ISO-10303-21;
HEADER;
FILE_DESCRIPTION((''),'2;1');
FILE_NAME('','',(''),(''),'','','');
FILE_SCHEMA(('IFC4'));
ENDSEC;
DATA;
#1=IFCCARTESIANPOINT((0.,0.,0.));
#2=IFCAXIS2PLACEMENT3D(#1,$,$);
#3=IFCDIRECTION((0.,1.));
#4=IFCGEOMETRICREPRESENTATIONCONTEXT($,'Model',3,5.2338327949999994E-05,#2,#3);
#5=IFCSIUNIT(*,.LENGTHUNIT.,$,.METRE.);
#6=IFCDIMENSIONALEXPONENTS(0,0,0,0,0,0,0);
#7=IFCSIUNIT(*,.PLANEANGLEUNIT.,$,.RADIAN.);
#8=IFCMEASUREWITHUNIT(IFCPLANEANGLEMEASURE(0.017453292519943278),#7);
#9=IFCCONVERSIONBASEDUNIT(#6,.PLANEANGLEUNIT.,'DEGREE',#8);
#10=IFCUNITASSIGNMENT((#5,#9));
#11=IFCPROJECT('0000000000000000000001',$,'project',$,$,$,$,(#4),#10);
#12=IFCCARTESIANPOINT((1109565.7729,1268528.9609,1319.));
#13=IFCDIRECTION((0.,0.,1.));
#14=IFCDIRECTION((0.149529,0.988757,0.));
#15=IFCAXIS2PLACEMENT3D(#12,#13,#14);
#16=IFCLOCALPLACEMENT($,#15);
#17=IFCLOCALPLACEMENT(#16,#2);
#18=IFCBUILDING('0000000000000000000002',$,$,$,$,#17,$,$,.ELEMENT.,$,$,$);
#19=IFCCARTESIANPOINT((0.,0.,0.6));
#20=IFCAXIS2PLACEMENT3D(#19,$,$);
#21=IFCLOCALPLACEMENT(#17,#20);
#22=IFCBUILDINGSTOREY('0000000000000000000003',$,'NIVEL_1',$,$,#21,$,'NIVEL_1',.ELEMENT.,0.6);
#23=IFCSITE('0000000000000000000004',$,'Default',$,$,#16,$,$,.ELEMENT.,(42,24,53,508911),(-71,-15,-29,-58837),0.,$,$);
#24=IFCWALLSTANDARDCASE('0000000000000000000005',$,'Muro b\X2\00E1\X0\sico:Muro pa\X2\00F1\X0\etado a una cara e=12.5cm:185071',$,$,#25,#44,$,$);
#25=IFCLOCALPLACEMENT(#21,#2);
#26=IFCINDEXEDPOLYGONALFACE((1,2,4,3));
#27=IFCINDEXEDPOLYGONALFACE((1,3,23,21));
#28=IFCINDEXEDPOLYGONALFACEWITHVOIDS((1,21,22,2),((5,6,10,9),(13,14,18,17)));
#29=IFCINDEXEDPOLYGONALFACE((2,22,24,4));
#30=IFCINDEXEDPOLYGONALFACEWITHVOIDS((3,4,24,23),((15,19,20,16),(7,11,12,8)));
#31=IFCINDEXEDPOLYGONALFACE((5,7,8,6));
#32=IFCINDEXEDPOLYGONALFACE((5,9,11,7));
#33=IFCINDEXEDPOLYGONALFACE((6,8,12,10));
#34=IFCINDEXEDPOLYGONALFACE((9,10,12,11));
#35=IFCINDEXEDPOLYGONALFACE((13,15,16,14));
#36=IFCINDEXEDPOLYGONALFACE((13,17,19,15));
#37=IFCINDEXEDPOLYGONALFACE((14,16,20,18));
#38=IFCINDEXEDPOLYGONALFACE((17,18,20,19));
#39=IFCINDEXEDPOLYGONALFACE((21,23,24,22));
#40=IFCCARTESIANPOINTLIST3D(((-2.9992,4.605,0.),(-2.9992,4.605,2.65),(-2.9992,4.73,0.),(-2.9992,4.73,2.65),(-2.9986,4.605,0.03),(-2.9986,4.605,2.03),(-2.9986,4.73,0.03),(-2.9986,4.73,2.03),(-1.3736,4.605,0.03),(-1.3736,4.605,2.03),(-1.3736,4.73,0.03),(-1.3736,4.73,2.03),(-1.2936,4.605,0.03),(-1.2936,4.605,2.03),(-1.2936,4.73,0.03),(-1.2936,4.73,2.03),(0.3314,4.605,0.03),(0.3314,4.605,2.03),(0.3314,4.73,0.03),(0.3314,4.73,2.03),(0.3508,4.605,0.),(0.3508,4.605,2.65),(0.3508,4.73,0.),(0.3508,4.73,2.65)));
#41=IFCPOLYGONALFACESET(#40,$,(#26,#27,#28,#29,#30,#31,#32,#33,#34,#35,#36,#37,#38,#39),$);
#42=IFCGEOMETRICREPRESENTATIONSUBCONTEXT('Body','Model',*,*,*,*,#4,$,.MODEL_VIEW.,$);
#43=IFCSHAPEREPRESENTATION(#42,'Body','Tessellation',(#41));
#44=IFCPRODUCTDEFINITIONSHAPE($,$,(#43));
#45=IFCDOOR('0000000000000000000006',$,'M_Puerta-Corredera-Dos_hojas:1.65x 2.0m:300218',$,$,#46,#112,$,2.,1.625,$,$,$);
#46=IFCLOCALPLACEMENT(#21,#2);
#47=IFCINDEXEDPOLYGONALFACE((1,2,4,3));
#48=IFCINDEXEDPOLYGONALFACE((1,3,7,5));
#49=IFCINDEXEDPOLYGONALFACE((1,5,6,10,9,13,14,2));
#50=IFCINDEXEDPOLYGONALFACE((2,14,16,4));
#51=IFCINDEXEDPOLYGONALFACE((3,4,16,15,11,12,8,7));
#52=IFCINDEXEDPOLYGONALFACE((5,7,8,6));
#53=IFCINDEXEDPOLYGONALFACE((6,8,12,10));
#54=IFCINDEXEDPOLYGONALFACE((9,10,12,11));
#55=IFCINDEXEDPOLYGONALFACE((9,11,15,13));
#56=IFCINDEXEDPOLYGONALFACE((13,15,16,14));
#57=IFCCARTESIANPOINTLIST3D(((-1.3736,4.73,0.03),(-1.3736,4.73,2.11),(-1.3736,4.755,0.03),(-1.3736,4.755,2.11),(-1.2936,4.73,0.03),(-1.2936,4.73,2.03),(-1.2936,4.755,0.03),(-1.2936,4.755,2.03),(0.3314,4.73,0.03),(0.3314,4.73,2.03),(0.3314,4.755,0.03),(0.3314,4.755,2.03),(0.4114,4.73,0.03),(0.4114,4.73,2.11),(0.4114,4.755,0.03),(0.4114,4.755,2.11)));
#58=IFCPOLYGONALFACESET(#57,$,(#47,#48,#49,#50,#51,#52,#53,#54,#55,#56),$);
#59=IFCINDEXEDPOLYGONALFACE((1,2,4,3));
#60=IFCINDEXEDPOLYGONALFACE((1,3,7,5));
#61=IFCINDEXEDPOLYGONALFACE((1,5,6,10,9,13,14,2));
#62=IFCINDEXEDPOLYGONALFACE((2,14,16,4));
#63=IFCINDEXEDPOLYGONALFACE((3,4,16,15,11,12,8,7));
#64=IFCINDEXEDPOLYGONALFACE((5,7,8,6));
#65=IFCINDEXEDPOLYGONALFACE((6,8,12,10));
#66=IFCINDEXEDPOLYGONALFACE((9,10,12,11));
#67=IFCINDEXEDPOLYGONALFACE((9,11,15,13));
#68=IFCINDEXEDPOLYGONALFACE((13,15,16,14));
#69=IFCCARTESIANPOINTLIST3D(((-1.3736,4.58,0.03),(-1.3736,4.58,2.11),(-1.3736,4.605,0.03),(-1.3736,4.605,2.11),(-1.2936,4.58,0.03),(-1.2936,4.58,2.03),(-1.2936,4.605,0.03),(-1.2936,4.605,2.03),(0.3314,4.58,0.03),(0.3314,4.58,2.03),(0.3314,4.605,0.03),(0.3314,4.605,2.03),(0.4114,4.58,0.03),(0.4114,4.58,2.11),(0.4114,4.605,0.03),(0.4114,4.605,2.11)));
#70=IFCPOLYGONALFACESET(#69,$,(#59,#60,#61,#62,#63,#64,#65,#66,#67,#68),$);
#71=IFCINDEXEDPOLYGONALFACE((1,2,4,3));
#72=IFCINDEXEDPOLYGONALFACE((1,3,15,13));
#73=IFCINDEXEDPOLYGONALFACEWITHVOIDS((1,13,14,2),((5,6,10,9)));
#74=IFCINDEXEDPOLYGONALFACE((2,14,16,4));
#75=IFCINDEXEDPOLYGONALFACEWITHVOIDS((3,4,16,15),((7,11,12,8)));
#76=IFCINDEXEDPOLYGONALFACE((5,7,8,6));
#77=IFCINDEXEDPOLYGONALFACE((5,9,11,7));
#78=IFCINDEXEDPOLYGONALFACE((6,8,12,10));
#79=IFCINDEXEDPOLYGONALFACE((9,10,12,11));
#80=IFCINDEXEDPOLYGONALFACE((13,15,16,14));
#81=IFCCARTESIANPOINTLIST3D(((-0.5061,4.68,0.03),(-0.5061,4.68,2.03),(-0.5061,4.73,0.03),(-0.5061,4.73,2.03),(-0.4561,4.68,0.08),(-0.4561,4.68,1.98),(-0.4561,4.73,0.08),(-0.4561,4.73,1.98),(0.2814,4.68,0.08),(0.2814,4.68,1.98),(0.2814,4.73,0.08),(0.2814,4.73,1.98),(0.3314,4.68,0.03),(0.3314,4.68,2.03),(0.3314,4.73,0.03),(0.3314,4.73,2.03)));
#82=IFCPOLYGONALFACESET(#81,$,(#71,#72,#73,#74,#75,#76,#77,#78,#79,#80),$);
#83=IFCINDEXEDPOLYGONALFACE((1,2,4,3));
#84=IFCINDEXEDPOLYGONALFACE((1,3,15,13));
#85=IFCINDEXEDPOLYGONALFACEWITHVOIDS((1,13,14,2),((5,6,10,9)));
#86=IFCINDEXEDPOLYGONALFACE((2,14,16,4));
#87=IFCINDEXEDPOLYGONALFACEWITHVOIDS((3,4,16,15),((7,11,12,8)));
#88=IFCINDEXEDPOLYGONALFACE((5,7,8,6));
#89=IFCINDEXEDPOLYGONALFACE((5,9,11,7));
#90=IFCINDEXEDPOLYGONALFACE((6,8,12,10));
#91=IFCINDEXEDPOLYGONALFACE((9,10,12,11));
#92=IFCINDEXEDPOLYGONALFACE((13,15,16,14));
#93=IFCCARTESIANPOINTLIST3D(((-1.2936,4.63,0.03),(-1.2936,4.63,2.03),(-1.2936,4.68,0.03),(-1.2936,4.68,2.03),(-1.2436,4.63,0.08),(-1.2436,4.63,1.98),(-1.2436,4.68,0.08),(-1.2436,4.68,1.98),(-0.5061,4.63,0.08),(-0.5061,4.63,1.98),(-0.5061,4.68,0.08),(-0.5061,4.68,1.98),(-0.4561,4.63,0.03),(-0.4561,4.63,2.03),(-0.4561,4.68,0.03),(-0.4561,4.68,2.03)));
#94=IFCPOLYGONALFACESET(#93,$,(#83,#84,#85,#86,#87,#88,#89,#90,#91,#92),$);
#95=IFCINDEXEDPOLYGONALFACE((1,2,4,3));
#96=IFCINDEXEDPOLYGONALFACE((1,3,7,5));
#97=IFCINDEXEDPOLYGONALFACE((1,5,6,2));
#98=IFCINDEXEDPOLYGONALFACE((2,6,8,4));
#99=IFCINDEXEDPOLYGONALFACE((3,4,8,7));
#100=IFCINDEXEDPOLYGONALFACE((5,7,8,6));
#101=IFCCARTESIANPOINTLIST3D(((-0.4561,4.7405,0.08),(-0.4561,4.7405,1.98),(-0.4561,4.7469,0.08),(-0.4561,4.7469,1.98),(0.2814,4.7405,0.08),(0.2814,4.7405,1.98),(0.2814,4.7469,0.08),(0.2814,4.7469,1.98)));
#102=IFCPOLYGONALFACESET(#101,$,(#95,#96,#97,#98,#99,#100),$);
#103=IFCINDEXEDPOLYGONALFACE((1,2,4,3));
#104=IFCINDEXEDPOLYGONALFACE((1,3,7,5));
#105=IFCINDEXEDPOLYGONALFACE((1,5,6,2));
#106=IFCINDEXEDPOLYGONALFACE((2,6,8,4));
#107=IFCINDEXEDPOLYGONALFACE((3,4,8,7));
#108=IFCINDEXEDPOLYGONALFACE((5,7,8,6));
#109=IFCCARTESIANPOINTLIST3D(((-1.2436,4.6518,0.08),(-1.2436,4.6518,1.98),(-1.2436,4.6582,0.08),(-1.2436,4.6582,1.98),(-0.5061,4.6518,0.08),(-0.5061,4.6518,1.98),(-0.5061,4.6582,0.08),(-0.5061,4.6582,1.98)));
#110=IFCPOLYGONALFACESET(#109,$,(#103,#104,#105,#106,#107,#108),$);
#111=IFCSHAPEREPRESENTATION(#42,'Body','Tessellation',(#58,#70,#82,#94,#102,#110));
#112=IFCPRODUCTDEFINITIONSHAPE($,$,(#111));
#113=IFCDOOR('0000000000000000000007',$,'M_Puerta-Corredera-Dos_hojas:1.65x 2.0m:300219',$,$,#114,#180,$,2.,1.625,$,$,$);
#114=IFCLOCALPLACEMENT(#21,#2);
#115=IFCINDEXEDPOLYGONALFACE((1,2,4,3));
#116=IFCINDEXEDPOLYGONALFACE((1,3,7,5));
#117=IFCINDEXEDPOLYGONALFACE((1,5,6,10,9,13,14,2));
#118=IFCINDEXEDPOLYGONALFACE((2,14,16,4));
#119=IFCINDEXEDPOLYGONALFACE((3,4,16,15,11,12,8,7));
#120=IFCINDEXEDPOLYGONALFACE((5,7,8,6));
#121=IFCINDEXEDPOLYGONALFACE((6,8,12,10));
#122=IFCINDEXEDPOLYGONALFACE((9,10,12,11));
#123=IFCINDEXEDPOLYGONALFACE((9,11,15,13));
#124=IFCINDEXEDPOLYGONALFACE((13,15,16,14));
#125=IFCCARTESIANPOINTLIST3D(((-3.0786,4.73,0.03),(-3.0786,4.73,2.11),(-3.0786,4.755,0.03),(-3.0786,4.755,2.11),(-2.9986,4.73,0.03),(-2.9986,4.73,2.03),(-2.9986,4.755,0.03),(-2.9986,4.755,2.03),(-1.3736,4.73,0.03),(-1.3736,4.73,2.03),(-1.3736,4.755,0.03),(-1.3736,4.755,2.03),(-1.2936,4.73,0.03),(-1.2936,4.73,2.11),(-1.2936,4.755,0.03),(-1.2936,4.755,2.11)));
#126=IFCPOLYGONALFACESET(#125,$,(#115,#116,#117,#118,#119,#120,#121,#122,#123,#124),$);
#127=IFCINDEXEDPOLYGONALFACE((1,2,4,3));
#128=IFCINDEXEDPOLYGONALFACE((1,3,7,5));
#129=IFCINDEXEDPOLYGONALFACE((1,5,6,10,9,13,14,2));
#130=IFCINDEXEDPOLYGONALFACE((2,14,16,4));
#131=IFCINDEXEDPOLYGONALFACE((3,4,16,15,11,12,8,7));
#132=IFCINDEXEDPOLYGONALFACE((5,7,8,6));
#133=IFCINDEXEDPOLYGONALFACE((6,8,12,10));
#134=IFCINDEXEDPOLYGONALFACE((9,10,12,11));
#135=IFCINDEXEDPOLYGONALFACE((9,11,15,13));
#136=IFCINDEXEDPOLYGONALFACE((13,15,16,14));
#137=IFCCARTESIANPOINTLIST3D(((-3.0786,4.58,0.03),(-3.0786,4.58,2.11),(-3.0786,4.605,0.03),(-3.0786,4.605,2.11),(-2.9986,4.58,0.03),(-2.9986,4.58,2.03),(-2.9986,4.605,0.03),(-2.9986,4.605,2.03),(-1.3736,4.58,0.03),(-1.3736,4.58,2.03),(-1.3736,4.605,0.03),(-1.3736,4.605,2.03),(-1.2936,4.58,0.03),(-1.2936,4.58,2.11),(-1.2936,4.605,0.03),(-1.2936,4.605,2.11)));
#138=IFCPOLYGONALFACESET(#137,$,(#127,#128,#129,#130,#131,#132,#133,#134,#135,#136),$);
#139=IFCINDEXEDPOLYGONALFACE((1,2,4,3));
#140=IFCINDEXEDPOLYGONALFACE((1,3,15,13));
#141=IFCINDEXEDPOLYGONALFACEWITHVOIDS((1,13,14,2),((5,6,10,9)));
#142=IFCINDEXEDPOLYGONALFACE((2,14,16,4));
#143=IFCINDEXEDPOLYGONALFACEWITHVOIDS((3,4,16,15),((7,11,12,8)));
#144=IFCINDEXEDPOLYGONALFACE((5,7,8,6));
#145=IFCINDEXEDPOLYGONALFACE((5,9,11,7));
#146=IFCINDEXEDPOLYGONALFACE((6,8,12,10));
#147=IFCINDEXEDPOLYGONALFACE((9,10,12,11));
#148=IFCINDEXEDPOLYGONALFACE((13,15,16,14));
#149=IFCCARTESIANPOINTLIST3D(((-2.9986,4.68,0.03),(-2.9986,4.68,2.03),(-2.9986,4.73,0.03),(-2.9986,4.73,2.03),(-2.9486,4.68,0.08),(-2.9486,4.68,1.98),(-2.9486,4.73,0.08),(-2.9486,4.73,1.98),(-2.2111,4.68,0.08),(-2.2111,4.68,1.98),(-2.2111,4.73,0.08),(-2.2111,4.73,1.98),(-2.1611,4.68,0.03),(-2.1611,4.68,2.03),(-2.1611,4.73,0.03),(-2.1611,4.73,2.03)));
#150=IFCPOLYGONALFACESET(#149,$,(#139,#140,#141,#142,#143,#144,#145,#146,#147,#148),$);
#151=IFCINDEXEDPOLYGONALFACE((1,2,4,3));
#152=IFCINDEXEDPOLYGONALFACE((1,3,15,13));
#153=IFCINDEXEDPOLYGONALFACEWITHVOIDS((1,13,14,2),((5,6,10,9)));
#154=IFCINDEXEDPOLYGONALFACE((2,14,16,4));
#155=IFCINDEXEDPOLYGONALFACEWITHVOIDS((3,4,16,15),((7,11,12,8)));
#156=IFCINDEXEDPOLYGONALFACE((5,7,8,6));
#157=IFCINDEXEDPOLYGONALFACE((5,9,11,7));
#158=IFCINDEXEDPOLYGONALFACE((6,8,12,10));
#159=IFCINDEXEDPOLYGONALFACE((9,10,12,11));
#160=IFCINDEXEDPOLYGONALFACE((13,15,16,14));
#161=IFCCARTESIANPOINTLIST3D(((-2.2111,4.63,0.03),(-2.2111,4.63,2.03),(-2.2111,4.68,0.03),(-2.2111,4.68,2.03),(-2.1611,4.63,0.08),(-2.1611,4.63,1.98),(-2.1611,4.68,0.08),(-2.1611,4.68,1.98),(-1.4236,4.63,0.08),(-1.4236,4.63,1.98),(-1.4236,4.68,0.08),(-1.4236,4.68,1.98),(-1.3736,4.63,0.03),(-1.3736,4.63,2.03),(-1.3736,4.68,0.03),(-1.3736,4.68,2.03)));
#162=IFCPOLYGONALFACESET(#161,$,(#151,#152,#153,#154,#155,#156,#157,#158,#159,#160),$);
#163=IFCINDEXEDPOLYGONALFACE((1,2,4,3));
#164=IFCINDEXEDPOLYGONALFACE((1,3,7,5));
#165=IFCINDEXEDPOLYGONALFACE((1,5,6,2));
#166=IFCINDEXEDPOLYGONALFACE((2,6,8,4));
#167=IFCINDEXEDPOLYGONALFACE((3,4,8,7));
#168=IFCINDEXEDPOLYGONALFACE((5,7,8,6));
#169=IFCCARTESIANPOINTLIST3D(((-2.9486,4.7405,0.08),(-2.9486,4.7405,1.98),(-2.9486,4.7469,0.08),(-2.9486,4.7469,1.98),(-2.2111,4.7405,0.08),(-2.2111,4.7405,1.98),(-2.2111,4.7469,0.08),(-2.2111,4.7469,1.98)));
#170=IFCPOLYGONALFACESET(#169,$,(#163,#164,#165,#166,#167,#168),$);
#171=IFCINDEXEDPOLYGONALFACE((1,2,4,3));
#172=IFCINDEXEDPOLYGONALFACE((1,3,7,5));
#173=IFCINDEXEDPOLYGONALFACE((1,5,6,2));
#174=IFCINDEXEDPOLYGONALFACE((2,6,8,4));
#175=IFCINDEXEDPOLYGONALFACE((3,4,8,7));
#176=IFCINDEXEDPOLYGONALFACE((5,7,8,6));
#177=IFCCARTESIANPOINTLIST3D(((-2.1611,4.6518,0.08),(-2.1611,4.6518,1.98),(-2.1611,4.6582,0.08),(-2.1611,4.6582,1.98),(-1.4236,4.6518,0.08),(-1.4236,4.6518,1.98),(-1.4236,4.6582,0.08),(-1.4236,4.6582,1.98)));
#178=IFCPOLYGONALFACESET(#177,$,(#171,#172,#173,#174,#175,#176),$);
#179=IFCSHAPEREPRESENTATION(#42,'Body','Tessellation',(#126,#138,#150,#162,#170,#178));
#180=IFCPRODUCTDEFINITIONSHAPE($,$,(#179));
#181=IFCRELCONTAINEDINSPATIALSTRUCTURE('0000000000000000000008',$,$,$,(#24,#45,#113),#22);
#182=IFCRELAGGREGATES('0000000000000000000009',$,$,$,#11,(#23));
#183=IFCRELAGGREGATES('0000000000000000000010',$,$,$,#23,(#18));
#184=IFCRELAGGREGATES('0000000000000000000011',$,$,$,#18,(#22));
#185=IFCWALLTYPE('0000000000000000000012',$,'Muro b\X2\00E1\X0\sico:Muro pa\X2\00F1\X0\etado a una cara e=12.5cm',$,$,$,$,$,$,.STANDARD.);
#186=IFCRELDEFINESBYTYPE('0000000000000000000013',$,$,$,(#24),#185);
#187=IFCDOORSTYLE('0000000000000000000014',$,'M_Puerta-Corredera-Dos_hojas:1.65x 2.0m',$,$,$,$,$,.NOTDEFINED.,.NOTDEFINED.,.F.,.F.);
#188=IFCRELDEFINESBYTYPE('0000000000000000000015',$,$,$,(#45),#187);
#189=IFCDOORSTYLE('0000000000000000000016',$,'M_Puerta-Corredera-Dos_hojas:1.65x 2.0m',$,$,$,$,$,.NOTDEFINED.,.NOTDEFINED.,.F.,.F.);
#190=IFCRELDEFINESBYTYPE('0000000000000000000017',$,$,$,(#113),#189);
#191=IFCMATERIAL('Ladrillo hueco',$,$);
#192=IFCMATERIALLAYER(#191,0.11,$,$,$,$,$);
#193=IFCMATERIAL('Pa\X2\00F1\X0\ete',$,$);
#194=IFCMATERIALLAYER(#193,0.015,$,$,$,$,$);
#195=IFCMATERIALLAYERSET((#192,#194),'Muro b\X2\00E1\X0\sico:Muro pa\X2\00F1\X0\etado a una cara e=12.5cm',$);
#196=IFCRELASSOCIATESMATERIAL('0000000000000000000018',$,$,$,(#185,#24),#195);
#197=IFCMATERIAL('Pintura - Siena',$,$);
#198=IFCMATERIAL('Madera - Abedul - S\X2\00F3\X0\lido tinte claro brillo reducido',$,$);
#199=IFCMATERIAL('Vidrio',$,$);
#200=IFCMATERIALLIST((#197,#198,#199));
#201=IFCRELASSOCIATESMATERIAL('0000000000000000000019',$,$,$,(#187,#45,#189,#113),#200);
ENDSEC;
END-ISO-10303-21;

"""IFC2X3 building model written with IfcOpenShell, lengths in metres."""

from ifc_helpers import new_model, entity, si_unit, converted_unit, direction, frame, frame_2d, origin, origin_2d_with_axis, place, context, subcontext, project, spatial, polyline, rectangle, outline, extrude, source, transform, mapped, material, material_list, layer, layer_set, layer_usage, type_object, type_shapes, element, fill, save


model = new_model("IFC2X3")

# Units and contexts
model_context = context("Model", 3, precision=5.2338327949999994e-05, world=origin(), true_north=direction((0.0, 1.0)))
body_context = subcontext(model_context, "Body", "Model", "MODEL_VIEW")
ifc_project = project(units=[si_unit("LENGTHUNIT", "METRE"), converted_unit("PLANEANGLEUNIT", "DEGREE", entity("IfcPlaneAngleMeasure", 0.017453292519943278), si_unit("PLANEANGLEUNIT", "RADIAN"), dimensions=[0, 0, 0, 0, 0, 0, 0])], contexts=[model_context])

# Site, building, storey
site_placement = place(None, frame((1109565.7729, 1268528.9609, 1319.0), z_axis=(0.0, 0.0, 1.0), x_axis=(0.149529, 0.988757, 0.0)))
site = spatial("IfcSite", under=ifc_project, at=site_placement, Name="Default", CompositionType="ELEMENT", RefLatitude=(42, 24, 53, 508911), RefLongitude=(-71, -15, -29, -58837), RefElevation=0.0)
building_placement = place(site_placement, origin())
building = spatial("IfcBuilding", under=site, at=building_placement, CompositionType="ELEMENT")
storey_placement = place(building_placement, frame((0.0, 0.0, 0.6)))
storey = spatial("IfcBuildingStorey", under=building, at=storey_placement, Name="NIVEL_1", LongName="NIVEL_1", CompositionType="ELEMENT", Elevation=0.6)

# Shared definitions
ifc_material_1 = material(Name="Pañete")
ifc_material_2 = material(Name="Ladrillo hueco")

# Wall, openings, doors
ifc_layer_1 = layer(ifc_material_2, 0.11)
ifc_layer_2 = layer(ifc_material_1, 0.015)
ifc_layer_set_1 = layer_set([ifc_layer_1, ifc_layer_2], Name="Muro básico:Muro pañetado a una cara e=12.5cm")
ifc_layer_usage_1 = layer_usage(ifc_layer_set_1, "AXIS2", "NEGATIVE", 0.0625)
wall_type_1 = type_object("IfcWallType", Name="Muro básico:Muro pañetado a una cara e=12.5cm", PredefinedType="STANDARD", material=ifc_layer_set_1)
wall_1_placement = place(storey_placement, frame((-2.9992, 4.6675, 0.0)))
wall_1 = element("IfcWallStandardCase", 1, at=wall_1_placement, inside=storey, type_object=wall_type_1, material=ifc_layer_usage_1, Name="Muro básico:Muro pañetado a una cara e=12.5cm:185071", context=body_context, shape_type="SweptSolid", body=[
    extrude(rectangle(XDim=3.35, YDim=0.125, at=frame_2d((1.675, 0.0), x_axis=(-1.0, 0.0))), origin(), (0.0, 0.0, 1.0), 2.65),
])
opening_1_placement = place(wall_1_placement, frame((0.0006, -0.0625, 0.03)))
opening_1 = element("IfcOpeningElement", 2, at=opening_1_placement, cuts=wall_1, ObjectType="Opening", context=body_context, shape_type="SweptSolid", body=[
    extrude(rectangle(XDim=2.0, YDim=1.625, at=frame_2d((1.0, 0.8125), x_axis=(-1.0, 0.0))), frame((0.0, 0.0, 0.0), z_axis=(0.0, 1.0, 0.0), x_axis=(0.0, 0.0, 1.0)), (0.0, 0.0, 1.0), 0.125),
])
opening_2_placement = place(wall_1_placement, frame((1.7056, -0.0625, 0.03)))
opening_2 = element("IfcOpeningElement", 3, at=opening_2_placement, cuts=wall_1, ObjectType="Opening", context=body_context, shape_type="SweptSolid", body=[
    extrude(rectangle(XDim=2.0, YDim=1.625, at=frame_2d((1.0, 0.8125), x_axis=(-1.0, 0.0))), frame((0.0, 0.0, 0.0), z_axis=(0.0, 1.0, 0.0), x_axis=(0.0, 0.0, 1.0)), (0.0, 0.0, 1.0), 0.125),
])
ifc_material_3 = material(Name="Pintura - Siena")
ifc_material_4 = material(Name="Madera - Abedul - Sólido tinte claro brillo reducido")
ifc_material_5 = material(Name="Vidrio")
ifc_material_list = material_list([ifc_material_3, ifc_material_4, ifc_material_5])
door_style_1 = type_object("IfcDoorStyle", Name="M_Puerta-Corredera-Dos_hojas:1.65x 2.0m", ConstructionType="NOTDEFINED", OperationType="NOTDEFINED", ParameterTakesPrecedence=False, Sizeable=False, material=ifc_material_list)
shared_shape_1 = source(origin(), body_context, "Body", "SweptSolid", [
    extrude(outline(polyline([(-0.8925, -1.02), (-0.8125, -1.02), (-0.8125, 0.98), (0.8125, 0.98), (0.8125, -1.02), (0.8925, -1.02), (0.8925, 1.06), (-0.8925, 1.06), (-0.8925, -1.02)])), frame((0.8125, 0.404, 1.02), z_axis=(0.0, -1.0, 0.0), x_axis=(1.0, 0.0, 0.0)), (0.0, 0.0, 1.0), 0.025),
    extrude(outline(polyline([(-1.02, -0.8925), (1.06, -0.8925), (1.06, 0.8925), (-1.02, 0.8925), (-1.02, 0.8125), (0.98, 0.8125), (0.98, -0.8125), (-1.02, -0.8125), (-1.02, -0.8925)])), frame((0.8125, 0.254, 1.02), z_axis=(0.0, -1.0, 0.0), x_axis=(0.0, 0.0, 1.0)), (0.0, 0.0, 1.0), 0.025),
    extrude(outline(polyline([(-1.0, -0.4187), (1.0, -0.4187), (1.0, 0.4187), (-1.0, 0.4187), (-1.0, -0.4187)]), holes=[polyline([(-0.95, -0.3688), (-0.95, 0.3687), (0.95, 0.3687), (0.95, -0.3688), (-0.95, -0.3688)])]), frame((1.2063, 0.379, 1.0), z_axis=(0.0, -1.0, 0.0), x_axis=(0.0, 0.0, -1.0)), (0.0, 0.0, 1.0), 0.05),
    extrude(outline(polyline([(-0.4187, -1.0), (0.4187, -1.0), (0.4187, 1.0), (-0.4187, 1.0), (-0.4187, -1.0)]), holes=[polyline([(-0.3688, -0.95), (-0.3688, 0.95), (0.3688, 0.95), (0.3688, -0.95), (-0.3688, -0.95)])]), frame((0.4187, 0.329, 1.0), z_axis=(0.0, -1.0, 0.0), x_axis=(-1.0, 0.0, 0.0)), (0.0, 0.0, 1.0), 0.05),
    extrude(rectangle(XDim=0.7375, YDim=0.0064, at=origin_2d_with_axis()), frame((1.2062, 0.3927, 0.05)), (0.0, 0.0, 1.0), 1.9),
    extrude(rectangle(XDim=0.7375, YDim=0.0063, at=frame_2d((0.0, 0.0), x_axis=(1.0, 0.0))), frame((0.4187, 0.304, 0.05), z_axis=(0.0, 0.0, 1.0), x_axis=(-1.0, 0.0, 0.0)), (0.0, 0.0, 1.0), 1.9),
])
type_shapes(door_style_1, [shared_shape_1])
door_1_placement = place(opening_2_placement, frame((0.0, -0.254, 0.0)))
door_1 = element("IfcDoor", 4, at=door_1_placement, inside=storey, type_object=door_style_1, material=ifc_material_list, Name="M_Puerta-Corredera-Dos_hojas:1.65x 2.0m:300218", OverallHeight=2.0, OverallWidth=1.625, context=body_context, shape_type="MappedRepresentation", body=[
    mapped(shared_shape_1, transform((0.0, 0.0, 0.0), scale=1.0)),
])
fill(opening_2, door_1)
door_style_2 = type_object("IfcDoorStyle", Name="M_Puerta-Corredera-Dos_hojas:1.65x 2.0m", ConstructionType="NOTDEFINED", OperationType="NOTDEFINED", ParameterTakesPrecedence=False, Sizeable=False, material=ifc_material_list)
shared_shape_2 = source(origin(), body_context, "Body", "SweptSolid", [
    extrude(outline(polyline([(-0.8925, -1.02), (-0.8125, -1.02), (-0.8125, 0.98), (0.8125, 0.98), (0.8125, -1.02), (0.8925, -1.02), (0.8925, 1.06), (-0.8925, 1.06), (-0.8925, -1.02)])), frame((0.8125, 0.125, 1.02), z_axis=(0.0, 1.0, 0.0), x_axis=(-1.0, 0.0, 0.0)), (0.0, 0.0, 1.0), 0.025),
    extrude(outline(polyline([(-1.02, -0.8925), (1.06, -0.8925), (1.06, 0.8925), (-1.02, 0.8925), (-1.02, 0.8125), (0.98, 0.8125), (0.98, -0.8125), (-1.02, -0.8125), (-1.02, -0.8925)])), frame((0.8125, -0.025, 1.02), z_axis=(0.0, 1.0, 0.0), x_axis=(0.0, 0.0, 1.0)), (0.0, 0.0, 1.0), 0.025),
    extrude(outline(polyline([(-1.0, -0.4187), (1.0, -0.4187), (1.0, 0.4187), (-1.0, 0.4187), (-1.0, -0.4187)]), holes=[polyline([(-0.95, -0.3688), (-0.95, 0.3687), (0.95, 0.3687), (0.95, -0.3688), (-0.95, -0.3688)])]), frame((0.4188, 0.075, 1.0), z_axis=(0.0, 1.0, 0.0), x_axis=(0.0, 0.0, -1.0)), (0.0, 0.0, 1.0), 0.05),
    extrude(outline(polyline([(-0.4187, -1.0), (0.4187, -1.0), (0.4187, 1.0), (-0.4187, 1.0), (-0.4187, -1.0)]), holes=[polyline([(-0.3688, -0.95), (-0.3688, 0.95), (0.3688, 0.95), (0.3688, -0.95), (-0.3688, -0.95)])]), frame((1.2063, 0.025, 1.0), z_axis=(0.0, 1.0, 0.0), x_axis=(1.0, 0.0, 0.0)), (0.0, 0.0, 1.0), 0.05),
    extrude(rectangle(XDim=0.0064, YDim=0.7375, at=origin_2d_with_axis()), frame((0.4188, 0.1387, 0.05), z_axis=(0.0, 0.0, 1.0), x_axis=(0.0, 1.0, 0.0)), (0.0, 0.0, 1.0), 1.9),
    extrude(rectangle(XDim=0.0063, YDim=0.7375, at=frame_2d((0.0, 0.0), x_axis=(1.0, 0.0))), frame((1.2063, 0.05, 0.05), z_axis=(0.0, 0.0, 1.0), x_axis=(0.0, -1.0, 0.0)), (0.0, 0.0, 1.0), 1.9),
])
type_shapes(door_style_2, [shared_shape_2])
door_2_placement = place(opening_1_placement, origin())
door_2 = element("IfcDoor", 5, at=door_2_placement, inside=storey, type_object=door_style_2, material=ifc_material_list, Name="M_Puerta-Corredera-Dos_hojas:1.65x 2.0m:300219", OverallHeight=2.0, OverallWidth=1.625, context=body_context, shape_type="MappedRepresentation", body=[
    mapped(shared_shape_2, transform((0.0, 0.0, 0.0), scale=1.0)),
])
fill(opening_1, door_2)

save(model, "model.ifc")
